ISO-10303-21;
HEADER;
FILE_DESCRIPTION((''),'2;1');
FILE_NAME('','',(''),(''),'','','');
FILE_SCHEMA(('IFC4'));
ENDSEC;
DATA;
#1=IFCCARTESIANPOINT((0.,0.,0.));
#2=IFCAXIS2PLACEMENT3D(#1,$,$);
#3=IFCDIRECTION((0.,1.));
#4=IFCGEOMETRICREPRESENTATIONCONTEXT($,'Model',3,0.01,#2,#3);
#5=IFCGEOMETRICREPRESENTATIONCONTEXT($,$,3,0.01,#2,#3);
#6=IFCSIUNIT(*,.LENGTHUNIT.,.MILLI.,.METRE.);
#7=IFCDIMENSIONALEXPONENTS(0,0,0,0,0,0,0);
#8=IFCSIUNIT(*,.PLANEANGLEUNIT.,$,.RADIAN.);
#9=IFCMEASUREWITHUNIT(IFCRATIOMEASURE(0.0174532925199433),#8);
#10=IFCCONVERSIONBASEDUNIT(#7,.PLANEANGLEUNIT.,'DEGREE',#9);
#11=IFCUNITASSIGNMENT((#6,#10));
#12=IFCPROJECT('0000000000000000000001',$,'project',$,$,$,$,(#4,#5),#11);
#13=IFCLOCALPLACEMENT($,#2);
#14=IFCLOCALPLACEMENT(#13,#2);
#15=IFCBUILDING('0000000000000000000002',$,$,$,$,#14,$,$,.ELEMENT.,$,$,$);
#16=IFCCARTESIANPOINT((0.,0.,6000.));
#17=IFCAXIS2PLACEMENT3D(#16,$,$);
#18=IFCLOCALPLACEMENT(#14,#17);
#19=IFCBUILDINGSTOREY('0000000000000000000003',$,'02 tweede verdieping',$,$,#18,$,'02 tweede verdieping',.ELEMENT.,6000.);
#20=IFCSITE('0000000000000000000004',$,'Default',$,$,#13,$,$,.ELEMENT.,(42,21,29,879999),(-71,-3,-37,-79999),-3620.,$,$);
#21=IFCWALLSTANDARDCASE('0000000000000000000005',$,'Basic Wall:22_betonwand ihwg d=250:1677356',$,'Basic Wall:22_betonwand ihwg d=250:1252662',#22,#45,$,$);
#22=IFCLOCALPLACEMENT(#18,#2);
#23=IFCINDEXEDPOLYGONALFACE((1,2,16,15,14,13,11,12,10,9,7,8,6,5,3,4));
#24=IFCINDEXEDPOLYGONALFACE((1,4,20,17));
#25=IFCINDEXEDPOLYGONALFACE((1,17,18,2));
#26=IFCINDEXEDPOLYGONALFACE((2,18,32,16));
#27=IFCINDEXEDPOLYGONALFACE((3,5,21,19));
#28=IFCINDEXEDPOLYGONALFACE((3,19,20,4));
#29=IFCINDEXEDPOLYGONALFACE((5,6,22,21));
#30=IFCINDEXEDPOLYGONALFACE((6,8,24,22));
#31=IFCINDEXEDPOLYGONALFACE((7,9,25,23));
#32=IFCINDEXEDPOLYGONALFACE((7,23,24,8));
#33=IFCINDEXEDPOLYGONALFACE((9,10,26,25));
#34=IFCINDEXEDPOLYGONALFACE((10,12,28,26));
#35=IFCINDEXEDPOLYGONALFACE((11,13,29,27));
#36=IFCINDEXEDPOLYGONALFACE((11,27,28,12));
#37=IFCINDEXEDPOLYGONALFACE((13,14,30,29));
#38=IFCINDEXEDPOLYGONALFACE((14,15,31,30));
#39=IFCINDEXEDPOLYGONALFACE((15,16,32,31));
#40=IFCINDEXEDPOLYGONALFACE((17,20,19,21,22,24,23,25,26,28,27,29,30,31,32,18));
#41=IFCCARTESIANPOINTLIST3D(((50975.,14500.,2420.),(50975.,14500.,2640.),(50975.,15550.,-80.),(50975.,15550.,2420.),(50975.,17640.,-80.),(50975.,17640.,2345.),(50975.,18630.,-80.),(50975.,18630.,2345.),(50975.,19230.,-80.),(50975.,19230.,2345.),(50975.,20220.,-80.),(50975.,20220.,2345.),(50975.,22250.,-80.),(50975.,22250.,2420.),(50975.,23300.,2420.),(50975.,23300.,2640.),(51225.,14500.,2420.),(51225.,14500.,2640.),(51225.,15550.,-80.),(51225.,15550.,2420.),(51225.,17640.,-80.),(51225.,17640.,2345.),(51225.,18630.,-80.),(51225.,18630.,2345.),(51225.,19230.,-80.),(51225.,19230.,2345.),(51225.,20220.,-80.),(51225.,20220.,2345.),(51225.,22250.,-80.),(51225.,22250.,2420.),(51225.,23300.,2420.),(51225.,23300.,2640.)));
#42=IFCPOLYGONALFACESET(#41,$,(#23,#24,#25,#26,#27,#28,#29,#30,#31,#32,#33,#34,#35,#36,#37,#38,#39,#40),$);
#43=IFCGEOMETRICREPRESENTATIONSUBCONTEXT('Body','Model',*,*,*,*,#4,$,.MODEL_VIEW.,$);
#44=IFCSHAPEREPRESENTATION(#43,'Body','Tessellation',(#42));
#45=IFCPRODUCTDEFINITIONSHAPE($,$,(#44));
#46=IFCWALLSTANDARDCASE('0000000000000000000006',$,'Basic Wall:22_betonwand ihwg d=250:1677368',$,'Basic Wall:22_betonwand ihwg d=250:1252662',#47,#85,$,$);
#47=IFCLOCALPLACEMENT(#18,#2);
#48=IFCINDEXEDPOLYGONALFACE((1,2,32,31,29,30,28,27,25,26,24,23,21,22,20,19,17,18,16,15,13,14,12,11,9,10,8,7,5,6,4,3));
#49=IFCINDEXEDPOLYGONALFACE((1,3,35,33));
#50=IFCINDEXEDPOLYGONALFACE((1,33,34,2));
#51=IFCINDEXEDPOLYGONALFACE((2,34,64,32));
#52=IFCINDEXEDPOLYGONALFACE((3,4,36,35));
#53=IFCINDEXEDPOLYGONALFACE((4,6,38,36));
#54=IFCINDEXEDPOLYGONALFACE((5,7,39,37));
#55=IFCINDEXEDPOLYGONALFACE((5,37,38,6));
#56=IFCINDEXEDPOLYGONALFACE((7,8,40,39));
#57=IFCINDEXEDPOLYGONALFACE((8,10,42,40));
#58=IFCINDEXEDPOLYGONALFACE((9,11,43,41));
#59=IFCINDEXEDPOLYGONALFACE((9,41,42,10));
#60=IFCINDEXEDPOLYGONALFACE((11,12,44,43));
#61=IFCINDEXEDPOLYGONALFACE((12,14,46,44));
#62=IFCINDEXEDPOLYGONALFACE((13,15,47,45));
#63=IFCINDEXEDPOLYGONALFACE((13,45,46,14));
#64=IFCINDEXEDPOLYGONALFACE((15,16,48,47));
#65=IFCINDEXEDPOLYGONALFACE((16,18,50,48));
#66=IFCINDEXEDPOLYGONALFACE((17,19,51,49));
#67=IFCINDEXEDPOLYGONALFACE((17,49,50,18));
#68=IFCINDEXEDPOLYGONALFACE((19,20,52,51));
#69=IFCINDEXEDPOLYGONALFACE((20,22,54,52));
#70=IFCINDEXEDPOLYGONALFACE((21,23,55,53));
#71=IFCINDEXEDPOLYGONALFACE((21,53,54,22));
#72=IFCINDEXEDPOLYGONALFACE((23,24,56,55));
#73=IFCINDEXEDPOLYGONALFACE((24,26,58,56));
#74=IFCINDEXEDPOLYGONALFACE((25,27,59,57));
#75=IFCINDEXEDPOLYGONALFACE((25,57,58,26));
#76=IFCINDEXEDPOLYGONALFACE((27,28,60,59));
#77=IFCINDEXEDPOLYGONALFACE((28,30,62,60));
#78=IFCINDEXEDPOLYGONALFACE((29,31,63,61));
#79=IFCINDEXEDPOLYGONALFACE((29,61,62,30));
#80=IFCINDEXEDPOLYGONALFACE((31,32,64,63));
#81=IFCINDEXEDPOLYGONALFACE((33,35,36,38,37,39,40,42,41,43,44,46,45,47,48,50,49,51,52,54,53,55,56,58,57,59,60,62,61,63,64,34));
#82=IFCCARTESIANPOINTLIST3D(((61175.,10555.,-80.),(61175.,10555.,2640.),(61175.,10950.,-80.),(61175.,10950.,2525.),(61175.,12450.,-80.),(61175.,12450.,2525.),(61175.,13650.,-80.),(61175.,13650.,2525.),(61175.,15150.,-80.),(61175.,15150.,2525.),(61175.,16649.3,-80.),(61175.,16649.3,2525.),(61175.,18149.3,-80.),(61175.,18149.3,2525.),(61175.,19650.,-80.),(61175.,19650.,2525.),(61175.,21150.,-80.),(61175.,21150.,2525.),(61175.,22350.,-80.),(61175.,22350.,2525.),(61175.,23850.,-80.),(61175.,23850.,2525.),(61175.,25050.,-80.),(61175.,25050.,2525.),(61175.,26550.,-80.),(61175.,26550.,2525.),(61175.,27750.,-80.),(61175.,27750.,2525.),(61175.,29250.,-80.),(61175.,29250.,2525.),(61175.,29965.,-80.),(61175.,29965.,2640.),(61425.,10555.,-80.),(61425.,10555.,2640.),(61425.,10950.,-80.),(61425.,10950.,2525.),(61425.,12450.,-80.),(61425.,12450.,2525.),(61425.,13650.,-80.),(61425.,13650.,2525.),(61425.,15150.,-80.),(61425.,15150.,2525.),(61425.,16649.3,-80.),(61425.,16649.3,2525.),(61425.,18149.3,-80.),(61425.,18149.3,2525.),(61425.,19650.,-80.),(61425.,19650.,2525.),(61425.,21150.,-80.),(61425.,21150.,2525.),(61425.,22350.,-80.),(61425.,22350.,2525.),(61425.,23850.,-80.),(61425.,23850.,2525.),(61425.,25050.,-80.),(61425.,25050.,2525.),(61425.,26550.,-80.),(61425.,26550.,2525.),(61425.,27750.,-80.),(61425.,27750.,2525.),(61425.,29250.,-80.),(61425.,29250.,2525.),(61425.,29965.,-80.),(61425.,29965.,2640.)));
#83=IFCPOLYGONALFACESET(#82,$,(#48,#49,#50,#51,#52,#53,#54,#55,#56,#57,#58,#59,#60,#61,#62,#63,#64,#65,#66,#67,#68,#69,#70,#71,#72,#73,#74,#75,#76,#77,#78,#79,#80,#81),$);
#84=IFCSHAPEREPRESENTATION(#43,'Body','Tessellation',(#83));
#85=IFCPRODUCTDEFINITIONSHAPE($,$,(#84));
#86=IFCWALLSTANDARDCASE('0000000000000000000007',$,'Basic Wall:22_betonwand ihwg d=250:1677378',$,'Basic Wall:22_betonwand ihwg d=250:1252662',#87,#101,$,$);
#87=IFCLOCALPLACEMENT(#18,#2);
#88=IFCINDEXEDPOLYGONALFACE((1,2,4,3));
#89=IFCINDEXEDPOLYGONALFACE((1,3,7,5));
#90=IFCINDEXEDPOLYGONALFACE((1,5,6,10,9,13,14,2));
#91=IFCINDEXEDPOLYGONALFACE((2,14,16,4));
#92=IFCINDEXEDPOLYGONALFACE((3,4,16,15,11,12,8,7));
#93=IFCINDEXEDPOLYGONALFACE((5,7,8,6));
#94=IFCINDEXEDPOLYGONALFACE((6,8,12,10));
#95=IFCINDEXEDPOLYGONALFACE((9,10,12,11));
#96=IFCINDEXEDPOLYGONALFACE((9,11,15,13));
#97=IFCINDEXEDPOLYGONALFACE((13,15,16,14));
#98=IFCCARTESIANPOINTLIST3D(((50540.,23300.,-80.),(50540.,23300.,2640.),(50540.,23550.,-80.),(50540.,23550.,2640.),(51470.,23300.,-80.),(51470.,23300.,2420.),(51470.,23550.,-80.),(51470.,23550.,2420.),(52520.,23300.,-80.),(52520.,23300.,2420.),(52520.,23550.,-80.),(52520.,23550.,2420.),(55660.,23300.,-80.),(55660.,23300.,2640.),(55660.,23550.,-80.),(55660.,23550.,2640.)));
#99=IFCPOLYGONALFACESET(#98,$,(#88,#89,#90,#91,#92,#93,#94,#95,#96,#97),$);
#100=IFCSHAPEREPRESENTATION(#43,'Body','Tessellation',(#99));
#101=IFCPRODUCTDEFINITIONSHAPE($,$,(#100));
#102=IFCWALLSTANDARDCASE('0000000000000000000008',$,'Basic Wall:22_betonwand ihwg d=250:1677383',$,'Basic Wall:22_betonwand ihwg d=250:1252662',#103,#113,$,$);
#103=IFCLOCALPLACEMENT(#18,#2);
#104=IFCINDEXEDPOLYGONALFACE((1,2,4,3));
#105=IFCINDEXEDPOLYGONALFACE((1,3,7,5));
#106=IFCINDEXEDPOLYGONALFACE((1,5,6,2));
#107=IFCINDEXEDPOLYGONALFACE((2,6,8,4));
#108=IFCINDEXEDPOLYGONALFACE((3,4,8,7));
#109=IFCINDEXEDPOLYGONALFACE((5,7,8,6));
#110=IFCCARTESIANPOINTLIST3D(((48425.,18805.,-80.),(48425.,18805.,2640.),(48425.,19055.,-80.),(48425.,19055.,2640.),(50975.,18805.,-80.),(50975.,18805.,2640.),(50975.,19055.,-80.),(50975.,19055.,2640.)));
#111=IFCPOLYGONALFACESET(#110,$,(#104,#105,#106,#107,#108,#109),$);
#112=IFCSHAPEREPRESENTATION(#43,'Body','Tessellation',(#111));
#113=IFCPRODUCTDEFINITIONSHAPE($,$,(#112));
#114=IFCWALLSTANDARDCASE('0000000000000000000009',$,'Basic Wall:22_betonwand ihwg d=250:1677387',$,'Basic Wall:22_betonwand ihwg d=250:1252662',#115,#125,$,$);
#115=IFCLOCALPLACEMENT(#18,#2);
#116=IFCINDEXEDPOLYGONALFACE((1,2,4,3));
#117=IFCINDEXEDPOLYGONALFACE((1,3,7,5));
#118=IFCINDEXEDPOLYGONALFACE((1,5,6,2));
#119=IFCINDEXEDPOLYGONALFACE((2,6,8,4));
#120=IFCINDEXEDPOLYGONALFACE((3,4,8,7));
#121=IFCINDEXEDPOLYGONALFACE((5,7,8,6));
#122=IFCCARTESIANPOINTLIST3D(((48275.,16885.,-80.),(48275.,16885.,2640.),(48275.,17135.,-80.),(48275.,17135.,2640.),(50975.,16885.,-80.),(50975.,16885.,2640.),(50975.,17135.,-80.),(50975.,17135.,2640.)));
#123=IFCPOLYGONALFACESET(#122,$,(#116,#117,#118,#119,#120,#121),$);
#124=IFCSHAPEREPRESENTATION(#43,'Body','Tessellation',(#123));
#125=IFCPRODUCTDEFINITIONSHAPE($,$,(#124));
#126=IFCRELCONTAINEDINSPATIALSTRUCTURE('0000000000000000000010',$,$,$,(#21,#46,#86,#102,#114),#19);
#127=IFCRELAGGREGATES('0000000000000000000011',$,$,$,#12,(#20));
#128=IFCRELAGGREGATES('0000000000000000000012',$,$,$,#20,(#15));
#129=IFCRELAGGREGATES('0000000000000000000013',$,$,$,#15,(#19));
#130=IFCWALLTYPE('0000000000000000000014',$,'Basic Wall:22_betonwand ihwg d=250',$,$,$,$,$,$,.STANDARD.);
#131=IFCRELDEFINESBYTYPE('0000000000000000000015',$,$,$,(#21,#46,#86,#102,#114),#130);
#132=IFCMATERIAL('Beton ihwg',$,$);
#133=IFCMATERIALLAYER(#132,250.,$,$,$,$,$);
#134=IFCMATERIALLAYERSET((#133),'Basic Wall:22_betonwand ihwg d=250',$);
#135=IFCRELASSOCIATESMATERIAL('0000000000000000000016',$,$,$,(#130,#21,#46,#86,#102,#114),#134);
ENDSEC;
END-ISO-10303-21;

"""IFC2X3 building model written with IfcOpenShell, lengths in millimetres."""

from ifc_helpers import new_model, entity, si_unit, converted_unit, direction, frame, frame_2d, origin, place, context, subcontext, project, spatial, rectangle, extrude, material, layer, layer_set, layer_usage, type_object, element, save


model = new_model("IFC2X3")

# Units and contexts
model_context = context("Model", 3, precision=0.01, world=origin(), true_north=direction((0.0, 1.0)))
context_of_model = context(None, 3, precision=0.01, world=origin(), true_north=direction((0.0, 1.0)))
body_context = subcontext(model_context, "Body", "Model", "MODEL_VIEW")
ifc_project = project(units=[si_unit("LENGTHUNIT", "METRE", prefix="MILLI"), converted_unit("PLANEANGLEUNIT", "DEGREE", entity("IfcRatioMeasure", 0.0174532925199433), si_unit("PLANEANGLEUNIT", "RADIAN"), dimensions=[0, 0, 0, 0, 0, 0, 0])], contexts=[model_context, context_of_model])

# Site, building, storey
site_placement = place(None, origin())
site = spatial("IfcSite", under=ifc_project, at=site_placement, Name="Default", CompositionType="ELEMENT", RefLatitude=(42, 21, 29, 879999), RefLongitude=(-71, -3, -37, -79999), RefElevation=-3620.0)
building_placement = place(site_placement, origin())
building = spatial("IfcBuilding", under=site, at=building_placement, CompositionType="ELEMENT")
storey_placement = place(building_placement, frame((0.0, 0.0, 6000.0)))
storey = spatial("IfcBuildingStorey", under=building, at=storey_placement, Name="02 tweede verdieping", LongName="02 tweede verdieping", CompositionType="ELEMENT", Elevation=6000.0)

# Walls, openings
ifc_material_1 = material(Name="Beton ihwg")
ifc_layer_1 = layer(ifc_material_1, 250.0)
ifc_layer_set_1 = layer_set([ifc_layer_1], Name="Basic Wall:22_betonwand ihwg d=250")
ifc_layer_usage_1 = layer_usage(ifc_layer_set_1, "AXIS2", "NEGATIVE", 125.0)
wall_type_1 = type_object("IfcWallType", Name="Basic Wall:22_betonwand ihwg d=250", PredefinedType="STANDARD", material=ifc_layer_set_1)
wall_1_placement = place(storey_placement, frame((51100.0, 23300.0, -80.0), z_axis=(0.0, 0.0, 1.0), x_axis=(0.0, -1.0, 0.0)))
wall_1 = element("IfcWallStandardCase", 1, at=wall_1_placement, inside=storey, type_object=wall_type_1, material=ifc_layer_usage_1, Name="Basic Wall:22_betonwand ihwg d=250:1677356", ObjectType="Basic Wall:22_betonwand ihwg d=250:1252662", context=body_context, shape_type="SweptSolid", body=[
    extrude(rectangle(XDim=8800.0, YDim=250.0, at=frame_2d((4400.0, 0.0), x_axis=(-1.0, 0.0))), origin(), (0.0, 0.0, 1.0), 2720.0),
])
opening_1_placement = place(wall_1_placement, frame((23300.0, -51100.0, 80.0), z_axis=(0.0, 0.0, 1.0), x_axis=(0.0, 1.0, 0.0)))
element("IfcOpeningElement", 2, at=opening_1_placement, cuts=wall_1, ObjectType="Opening", context=body_context, shape_type="SweptSolid", body=[
    extrude(rectangle(XDim=2500.0, YDim=1050.0, at=frame_2d((0.0, 0.0), x_axis=(0.0, 1.0))), frame((50700.0, 15025.0, 1170.0), z_axis=(1.0, 0.0, 0.0), x_axis=(0.0, -1.0, 0.0)), (0.0, 0.0, 1.0), 800.0),
])
opening_2_placement = place(wall_1_placement, frame((23300.0, -51100.0, 80.0), z_axis=(0.0, 0.0, 1.0), x_axis=(0.0, 1.0, 0.0)))
element("IfcOpeningElement", 3, at=opening_2_placement, cuts=wall_1, ObjectType="Opening", context=body_context, shape_type="SweptSolid", body=[
    extrude(rectangle(XDim=2425.0, YDim=990.0, at=frame_2d((0.0, 0.0), x_axis=(1.0, 0.0))), frame((50700.0, 19725.0, 1132.5), z_axis=(1.0, 0.0, 0.0), x_axis=(0.0, 0.0, -1.0)), (0.0, 0.0, 1.0), 800.0),
])
opening_3_placement = place(wall_1_placement, frame((23300.0, -51100.0, 80.0), z_axis=(0.0, 0.0, 1.0), x_axis=(0.0, 1.0, 0.0)))
element("IfcOpeningElement", 4, at=opening_3_placement, cuts=wall_1, ObjectType="Opening", context=body_context, shape_type="SweptSolid", body=[
    extrude(rectangle(XDim=2425.0, YDim=990.0, at=frame_2d((0.0, 0.0), x_axis=(1.0, 0.0))), frame((50700.0, 18135.0, 1132.5), z_axis=(1.0, 0.0, 0.0), x_axis=(0.0, 0.0, -1.0)), (0.0, 0.0, 1.0), 800.0),
])
opening_4_placement = place(wall_1_placement, frame((23300.0, -51100.0, 80.0), z_axis=(0.0, 0.0, 1.0), x_axis=(0.0, 1.0, 0.0)))
element("IfcOpeningElement", 5, at=opening_4_placement, cuts=wall_1, ObjectType="Opening", context=body_context, shape_type="SweptSolid", body=[
    extrude(rectangle(XDim=2500.0, YDim=1050.0, at=frame_2d((0.0, 0.0), x_axis=(1.0, 0.0))), frame((50700.0, 22775.0, 1170.0), z_axis=(1.0, 0.0, 0.0), x_axis=(0.0, 0.0, -1.0)), (0.0, 0.0, 1.0), 800.0),
])
ifc_layer_usage_2 = layer_usage(ifc_layer_set_1, "AXIS2", "POSITIVE", -125.0)
wall_2_placement = place(storey_placement, frame((61300.0, 29965.0, -80.0), z_axis=(0.0, 0.0, 1.0), x_axis=(0.0, -1.0, 0.0)))
wall_2 = element("IfcWallStandardCase", 6, at=wall_2_placement, inside=storey, type_object=wall_type_1, material=ifc_layer_usage_2, Name="Basic Wall:22_betonwand ihwg d=250:1677368", ObjectType="Basic Wall:22_betonwand ihwg d=250:1252662", context=body_context, shape_type="SweptSolid", body=[
    extrude(rectangle(XDim=19410.0, YDim=250.0, at=frame_2d((9705.0, 0.0), x_axis=(-1.0, 0.0))), origin(), (0.0, 0.0, 1.0), 2720.0),
])
opening_5_placement = place(wall_2_placement, frame((29965.0, -61300.0, 80.0), z_axis=(0.0, 0.0, 1.0), x_axis=(0.0, 1.0, 0.0)))
element("IfcOpeningElement", 7, at=opening_5_placement, cuts=wall_2, ObjectType="Opening", context=body_context, shape_type="SweptSolid", body=[
    extrude(rectangle(XDim=2605.0, YDim=1500.0, at=frame_2d((0.0, 0.0), x_axis=(1.0, 0.0))), frame((59901.0, 28500.0, 1222.5), z_axis=(1.0, 0.0, 0.0), x_axis=(0.0, 0.0, -1.0)), (0.0, 0.0, 1.0), 3048.0),
])
opening_6_placement = place(wall_2_placement, frame((29965.0, -61300.0, 80.0), z_axis=(0.0, 0.0, 1.0), x_axis=(0.0, 1.0, 0.0)))
element("IfcOpeningElement", 8, at=opening_6_placement, cuts=wall_2, ObjectType="Opening", context=body_context, shape_type="SweptSolid", body=[
    extrude(rectangle(XDim=2605.0, YDim=1500.0, at=frame_2d((0.0, 0.0), x_axis=(1.0, 0.0))), frame((59901.0, 25800.0, 1222.5), z_axis=(1.0, 0.0, 0.0), x_axis=(0.0, 0.0, -1.0)), (0.0, 0.0, 1.0), 3048.0),
])
opening_7_placement = place(wall_2_placement, frame((29965.0, -61300.0, 80.0), z_axis=(0.0, 0.0, 1.0), x_axis=(0.0, 1.0, 0.0)))
element("IfcOpeningElement", 9, at=opening_7_placement, cuts=wall_2, ObjectType="Opening", context=body_context, shape_type="SweptSolid", body=[
    extrude(rectangle(XDim=2605.0, YDim=1500.0, at=frame_2d((0.0, 0.0), x_axis=(1.0, 0.0))), frame((59901.0, 23100.0, 1222.5), z_axis=(1.0, 0.0, 0.0), x_axis=(0.0, 0.0, -1.0)), (0.0, 0.0, 1.0), 3048.0),
])
opening_8_placement = place(wall_2_placement, frame((29965.0, -61300.0, 80.0), z_axis=(0.0, 0.0, 1.0), x_axis=(0.0, 1.0, 0.0)))
element("IfcOpeningElement", 10, at=opening_8_placement, cuts=wall_2, ObjectType="Opening", context=body_context, shape_type="SweptSolid", body=[
    extrude(rectangle(XDim=2605.0, YDim=1500.0, at=frame_2d((0.0, 0.0), x_axis=(1.0, 0.0))), frame((59901.0, 17399.3, 1222.5), z_axis=(1.0, 0.0, 0.0), x_axis=(0.0, 0.0, -1.0)), (0.0, 0.0, 1.0), 3048.0),
])
opening_9_placement = place(wall_2_placement, frame((29965.0, -61300.0, 80.0), z_axis=(0.0, 0.0, 1.0), x_axis=(0.0, 1.0, 0.0)))
element("IfcOpeningElement", 11, at=opening_9_placement, cuts=wall_2, ObjectType="Opening", context=body_context, shape_type="SweptSolid", body=[
    extrude(rectangle(XDim=2605.0, YDim=1500.0, at=frame_2d((0.0, 0.0), x_axis=(1.0, 0.0))), frame((59901.0, 14400.0, 1222.5), z_axis=(1.0, 0.0, 0.0), x_axis=(0.0, 0.0, -1.0)), (0.0, 0.0, 1.0), 3048.0),
])
opening_10_placement = place(wall_2_placement, frame((29965.0, -61300.0, 80.0), z_axis=(0.0, 0.0, 1.0), x_axis=(0.0, 1.0, 0.0)))
element("IfcOpeningElement", 12, at=opening_10_placement, cuts=wall_2, ObjectType="Opening", context=body_context, shape_type="SweptSolid", body=[
    extrude(rectangle(XDim=2605.0, YDim=1500.0, at=frame_2d((0.0, 0.0), x_axis=(1.0, 0.0))), frame((59901.0, 20400.0, 1222.5), z_axis=(1.0, 0.0, 0.0), x_axis=(0.0, 0.0, -1.0)), (0.0, 0.0, 1.0), 3048.0),
])
opening_11_placement = place(wall_2_placement, frame((29965.0, -61300.0, 80.0), z_axis=(0.0, 0.0, 1.0), x_axis=(0.0, 1.0, 0.0)))
element("IfcOpeningElement", 13, at=opening_11_placement, cuts=wall_2, ObjectType="Opening", context=body_context, shape_type="SweptSolid", body=[
    extrude(rectangle(XDim=2605.0, YDim=1500.0, at=frame_2d((0.0, 0.0), x_axis=(1.0, 0.0))), frame((59901.0, 11700.0, 1222.5), z_axis=(1.0, 0.0, 0.0), x_axis=(0.0, 0.0, -1.0)), (0.0, 0.0, 1.0), 3048.0),
])
ifc_layer_usage_3 = layer_usage(ifc_layer_set_1, "AXIS2", "POSITIVE", -125.0)
wall_3_placement = place(storey_placement, frame((55660.0, 23425.0, -80.0), z_axis=(0.0, 0.0, 1.0), x_axis=(-1.0, 0.0, 0.0)))
wall_3 = element("IfcWallStandardCase", 14, at=wall_3_placement, inside=storey, type_object=wall_type_1, material=ifc_layer_usage_3, Name="Basic Wall:22_betonwand ihwg d=250:1677378", ObjectType="Basic Wall:22_betonwand ihwg d=250:1252662", context=body_context, shape_type="SweptSolid", body=[
    extrude(rectangle(XDim=5120.0, YDim=250.0, at=frame_2d((2560.0, 0.0), x_axis=(-1.0, 0.0))), origin(), (0.0, 0.0, 1.0), 2720.0),
])
opening_12_placement = place(wall_3_placement, origin())
element("IfcOpeningElement", 15, at=opening_12_placement, cuts=wall_3, ObjectType="Opening", context=body_context, shape_type="SweptSolid", body=[
    extrude(rectangle(XDim=2500.0, YDim=800.0, at=frame_2d((0.0, 0.0), x_axis=(0.0, 1.0))), frame((2735.0, 125.0, 1250.0), z_axis=(0.0, 1.0, 0.0), x_axis=(1.0, 0.0, 0.0)), (0.0, 0.0, 1.0), 1034.0),
])
opening_13_placement = place(wall_3_placement, origin())
element("IfcOpeningElement", 16, at=opening_13_placement, cuts=wall_3, ObjectType="Opening", context=body_context, shape_type="SweptSolid", body=[
    extrude(rectangle(XDim=2500.0, YDim=800.0, at=frame_2d((0.0, 0.0), x_axis=(0.0, 1.0))), frame((4560.0, 125.0, 1250.0), z_axis=(0.0, 1.0, 0.0), x_axis=(1.0, 0.0, 0.0)), (0.0, 0.0, 1.0), 1050.0),
])
opening_14_placement = place(wall_3_placement, frame((55660.0, 23425.0, 80.0), z_axis=(0.0, 0.0, 1.0), x_axis=(-1.0, 0.0, 0.0)))
element("IfcOpeningElement", 17, at=opening_14_placement, cuts=wall_3, ObjectType="Opening", context=body_context, shape_type="SweptSolid", body=[
    extrude(rectangle(XDim=2500.0, YDim=1050.0, at=frame_2d((0.0, 0.0), x_axis=(0.0, 1.0))), frame((51995.0, 23825.0, 1170.0), z_axis=(0.0, -1.0, 0.0), x_axis=(-1.0, 0.0, 0.0)), (0.0, 0.0, 1.0), 800.0),
])

# Walls
ifc_layer_usage_4 = layer_usage(ifc_layer_set_1, "AXIS2", "POSITIVE", -125.0)
wall_4_placement = place(storey_placement, frame((50975.0, 18930.0, -80.0), z_axis=(0.0, 0.0, 1.0), x_axis=(-1.0, 0.0, 0.0)))
element("IfcWallStandardCase", 18, at=wall_4_placement, inside=storey, type_object=wall_type_1, material=ifc_layer_usage_4, Name="Basic Wall:22_betonwand ihwg d=250:1677383", ObjectType="Basic Wall:22_betonwand ihwg d=250:1252662", context=body_context, shape_type="SweptSolid", body=[
    extrude(rectangle(XDim=2550.0, YDim=250.0, at=frame_2d((1275.0, 0.0), x_axis=(-1.0, 0.0))), origin(), (0.0, 0.0, 1.0), 2720.0),
])
ifc_layer_usage_5 = layer_usage(ifc_layer_set_1, "AXIS2", "POSITIVE", -125.0)
wall_5_placement = place(storey_placement, frame((50975.0, 17010.0, -80.0), z_axis=(0.0, 0.0, 1.0), x_axis=(-1.0, 0.0, 0.0)))
element("IfcWallStandardCase", 19, at=wall_5_placement, inside=storey, type_object=wall_type_1, material=ifc_layer_usage_5, Name="Basic Wall:22_betonwand ihwg d=250:1677387", ObjectType="Basic Wall:22_betonwand ihwg d=250:1252662", context=body_context, shape_type="SweptSolid", body=[
    extrude(rectangle(XDim=2700.0, YDim=250.0, at=frame_2d((1350.0, 0.0), x_axis=(-1.0, 0.0))), origin(), (0.0, 0.0, 1.0), 2720.0),
])

save(model, "model.ifc")
